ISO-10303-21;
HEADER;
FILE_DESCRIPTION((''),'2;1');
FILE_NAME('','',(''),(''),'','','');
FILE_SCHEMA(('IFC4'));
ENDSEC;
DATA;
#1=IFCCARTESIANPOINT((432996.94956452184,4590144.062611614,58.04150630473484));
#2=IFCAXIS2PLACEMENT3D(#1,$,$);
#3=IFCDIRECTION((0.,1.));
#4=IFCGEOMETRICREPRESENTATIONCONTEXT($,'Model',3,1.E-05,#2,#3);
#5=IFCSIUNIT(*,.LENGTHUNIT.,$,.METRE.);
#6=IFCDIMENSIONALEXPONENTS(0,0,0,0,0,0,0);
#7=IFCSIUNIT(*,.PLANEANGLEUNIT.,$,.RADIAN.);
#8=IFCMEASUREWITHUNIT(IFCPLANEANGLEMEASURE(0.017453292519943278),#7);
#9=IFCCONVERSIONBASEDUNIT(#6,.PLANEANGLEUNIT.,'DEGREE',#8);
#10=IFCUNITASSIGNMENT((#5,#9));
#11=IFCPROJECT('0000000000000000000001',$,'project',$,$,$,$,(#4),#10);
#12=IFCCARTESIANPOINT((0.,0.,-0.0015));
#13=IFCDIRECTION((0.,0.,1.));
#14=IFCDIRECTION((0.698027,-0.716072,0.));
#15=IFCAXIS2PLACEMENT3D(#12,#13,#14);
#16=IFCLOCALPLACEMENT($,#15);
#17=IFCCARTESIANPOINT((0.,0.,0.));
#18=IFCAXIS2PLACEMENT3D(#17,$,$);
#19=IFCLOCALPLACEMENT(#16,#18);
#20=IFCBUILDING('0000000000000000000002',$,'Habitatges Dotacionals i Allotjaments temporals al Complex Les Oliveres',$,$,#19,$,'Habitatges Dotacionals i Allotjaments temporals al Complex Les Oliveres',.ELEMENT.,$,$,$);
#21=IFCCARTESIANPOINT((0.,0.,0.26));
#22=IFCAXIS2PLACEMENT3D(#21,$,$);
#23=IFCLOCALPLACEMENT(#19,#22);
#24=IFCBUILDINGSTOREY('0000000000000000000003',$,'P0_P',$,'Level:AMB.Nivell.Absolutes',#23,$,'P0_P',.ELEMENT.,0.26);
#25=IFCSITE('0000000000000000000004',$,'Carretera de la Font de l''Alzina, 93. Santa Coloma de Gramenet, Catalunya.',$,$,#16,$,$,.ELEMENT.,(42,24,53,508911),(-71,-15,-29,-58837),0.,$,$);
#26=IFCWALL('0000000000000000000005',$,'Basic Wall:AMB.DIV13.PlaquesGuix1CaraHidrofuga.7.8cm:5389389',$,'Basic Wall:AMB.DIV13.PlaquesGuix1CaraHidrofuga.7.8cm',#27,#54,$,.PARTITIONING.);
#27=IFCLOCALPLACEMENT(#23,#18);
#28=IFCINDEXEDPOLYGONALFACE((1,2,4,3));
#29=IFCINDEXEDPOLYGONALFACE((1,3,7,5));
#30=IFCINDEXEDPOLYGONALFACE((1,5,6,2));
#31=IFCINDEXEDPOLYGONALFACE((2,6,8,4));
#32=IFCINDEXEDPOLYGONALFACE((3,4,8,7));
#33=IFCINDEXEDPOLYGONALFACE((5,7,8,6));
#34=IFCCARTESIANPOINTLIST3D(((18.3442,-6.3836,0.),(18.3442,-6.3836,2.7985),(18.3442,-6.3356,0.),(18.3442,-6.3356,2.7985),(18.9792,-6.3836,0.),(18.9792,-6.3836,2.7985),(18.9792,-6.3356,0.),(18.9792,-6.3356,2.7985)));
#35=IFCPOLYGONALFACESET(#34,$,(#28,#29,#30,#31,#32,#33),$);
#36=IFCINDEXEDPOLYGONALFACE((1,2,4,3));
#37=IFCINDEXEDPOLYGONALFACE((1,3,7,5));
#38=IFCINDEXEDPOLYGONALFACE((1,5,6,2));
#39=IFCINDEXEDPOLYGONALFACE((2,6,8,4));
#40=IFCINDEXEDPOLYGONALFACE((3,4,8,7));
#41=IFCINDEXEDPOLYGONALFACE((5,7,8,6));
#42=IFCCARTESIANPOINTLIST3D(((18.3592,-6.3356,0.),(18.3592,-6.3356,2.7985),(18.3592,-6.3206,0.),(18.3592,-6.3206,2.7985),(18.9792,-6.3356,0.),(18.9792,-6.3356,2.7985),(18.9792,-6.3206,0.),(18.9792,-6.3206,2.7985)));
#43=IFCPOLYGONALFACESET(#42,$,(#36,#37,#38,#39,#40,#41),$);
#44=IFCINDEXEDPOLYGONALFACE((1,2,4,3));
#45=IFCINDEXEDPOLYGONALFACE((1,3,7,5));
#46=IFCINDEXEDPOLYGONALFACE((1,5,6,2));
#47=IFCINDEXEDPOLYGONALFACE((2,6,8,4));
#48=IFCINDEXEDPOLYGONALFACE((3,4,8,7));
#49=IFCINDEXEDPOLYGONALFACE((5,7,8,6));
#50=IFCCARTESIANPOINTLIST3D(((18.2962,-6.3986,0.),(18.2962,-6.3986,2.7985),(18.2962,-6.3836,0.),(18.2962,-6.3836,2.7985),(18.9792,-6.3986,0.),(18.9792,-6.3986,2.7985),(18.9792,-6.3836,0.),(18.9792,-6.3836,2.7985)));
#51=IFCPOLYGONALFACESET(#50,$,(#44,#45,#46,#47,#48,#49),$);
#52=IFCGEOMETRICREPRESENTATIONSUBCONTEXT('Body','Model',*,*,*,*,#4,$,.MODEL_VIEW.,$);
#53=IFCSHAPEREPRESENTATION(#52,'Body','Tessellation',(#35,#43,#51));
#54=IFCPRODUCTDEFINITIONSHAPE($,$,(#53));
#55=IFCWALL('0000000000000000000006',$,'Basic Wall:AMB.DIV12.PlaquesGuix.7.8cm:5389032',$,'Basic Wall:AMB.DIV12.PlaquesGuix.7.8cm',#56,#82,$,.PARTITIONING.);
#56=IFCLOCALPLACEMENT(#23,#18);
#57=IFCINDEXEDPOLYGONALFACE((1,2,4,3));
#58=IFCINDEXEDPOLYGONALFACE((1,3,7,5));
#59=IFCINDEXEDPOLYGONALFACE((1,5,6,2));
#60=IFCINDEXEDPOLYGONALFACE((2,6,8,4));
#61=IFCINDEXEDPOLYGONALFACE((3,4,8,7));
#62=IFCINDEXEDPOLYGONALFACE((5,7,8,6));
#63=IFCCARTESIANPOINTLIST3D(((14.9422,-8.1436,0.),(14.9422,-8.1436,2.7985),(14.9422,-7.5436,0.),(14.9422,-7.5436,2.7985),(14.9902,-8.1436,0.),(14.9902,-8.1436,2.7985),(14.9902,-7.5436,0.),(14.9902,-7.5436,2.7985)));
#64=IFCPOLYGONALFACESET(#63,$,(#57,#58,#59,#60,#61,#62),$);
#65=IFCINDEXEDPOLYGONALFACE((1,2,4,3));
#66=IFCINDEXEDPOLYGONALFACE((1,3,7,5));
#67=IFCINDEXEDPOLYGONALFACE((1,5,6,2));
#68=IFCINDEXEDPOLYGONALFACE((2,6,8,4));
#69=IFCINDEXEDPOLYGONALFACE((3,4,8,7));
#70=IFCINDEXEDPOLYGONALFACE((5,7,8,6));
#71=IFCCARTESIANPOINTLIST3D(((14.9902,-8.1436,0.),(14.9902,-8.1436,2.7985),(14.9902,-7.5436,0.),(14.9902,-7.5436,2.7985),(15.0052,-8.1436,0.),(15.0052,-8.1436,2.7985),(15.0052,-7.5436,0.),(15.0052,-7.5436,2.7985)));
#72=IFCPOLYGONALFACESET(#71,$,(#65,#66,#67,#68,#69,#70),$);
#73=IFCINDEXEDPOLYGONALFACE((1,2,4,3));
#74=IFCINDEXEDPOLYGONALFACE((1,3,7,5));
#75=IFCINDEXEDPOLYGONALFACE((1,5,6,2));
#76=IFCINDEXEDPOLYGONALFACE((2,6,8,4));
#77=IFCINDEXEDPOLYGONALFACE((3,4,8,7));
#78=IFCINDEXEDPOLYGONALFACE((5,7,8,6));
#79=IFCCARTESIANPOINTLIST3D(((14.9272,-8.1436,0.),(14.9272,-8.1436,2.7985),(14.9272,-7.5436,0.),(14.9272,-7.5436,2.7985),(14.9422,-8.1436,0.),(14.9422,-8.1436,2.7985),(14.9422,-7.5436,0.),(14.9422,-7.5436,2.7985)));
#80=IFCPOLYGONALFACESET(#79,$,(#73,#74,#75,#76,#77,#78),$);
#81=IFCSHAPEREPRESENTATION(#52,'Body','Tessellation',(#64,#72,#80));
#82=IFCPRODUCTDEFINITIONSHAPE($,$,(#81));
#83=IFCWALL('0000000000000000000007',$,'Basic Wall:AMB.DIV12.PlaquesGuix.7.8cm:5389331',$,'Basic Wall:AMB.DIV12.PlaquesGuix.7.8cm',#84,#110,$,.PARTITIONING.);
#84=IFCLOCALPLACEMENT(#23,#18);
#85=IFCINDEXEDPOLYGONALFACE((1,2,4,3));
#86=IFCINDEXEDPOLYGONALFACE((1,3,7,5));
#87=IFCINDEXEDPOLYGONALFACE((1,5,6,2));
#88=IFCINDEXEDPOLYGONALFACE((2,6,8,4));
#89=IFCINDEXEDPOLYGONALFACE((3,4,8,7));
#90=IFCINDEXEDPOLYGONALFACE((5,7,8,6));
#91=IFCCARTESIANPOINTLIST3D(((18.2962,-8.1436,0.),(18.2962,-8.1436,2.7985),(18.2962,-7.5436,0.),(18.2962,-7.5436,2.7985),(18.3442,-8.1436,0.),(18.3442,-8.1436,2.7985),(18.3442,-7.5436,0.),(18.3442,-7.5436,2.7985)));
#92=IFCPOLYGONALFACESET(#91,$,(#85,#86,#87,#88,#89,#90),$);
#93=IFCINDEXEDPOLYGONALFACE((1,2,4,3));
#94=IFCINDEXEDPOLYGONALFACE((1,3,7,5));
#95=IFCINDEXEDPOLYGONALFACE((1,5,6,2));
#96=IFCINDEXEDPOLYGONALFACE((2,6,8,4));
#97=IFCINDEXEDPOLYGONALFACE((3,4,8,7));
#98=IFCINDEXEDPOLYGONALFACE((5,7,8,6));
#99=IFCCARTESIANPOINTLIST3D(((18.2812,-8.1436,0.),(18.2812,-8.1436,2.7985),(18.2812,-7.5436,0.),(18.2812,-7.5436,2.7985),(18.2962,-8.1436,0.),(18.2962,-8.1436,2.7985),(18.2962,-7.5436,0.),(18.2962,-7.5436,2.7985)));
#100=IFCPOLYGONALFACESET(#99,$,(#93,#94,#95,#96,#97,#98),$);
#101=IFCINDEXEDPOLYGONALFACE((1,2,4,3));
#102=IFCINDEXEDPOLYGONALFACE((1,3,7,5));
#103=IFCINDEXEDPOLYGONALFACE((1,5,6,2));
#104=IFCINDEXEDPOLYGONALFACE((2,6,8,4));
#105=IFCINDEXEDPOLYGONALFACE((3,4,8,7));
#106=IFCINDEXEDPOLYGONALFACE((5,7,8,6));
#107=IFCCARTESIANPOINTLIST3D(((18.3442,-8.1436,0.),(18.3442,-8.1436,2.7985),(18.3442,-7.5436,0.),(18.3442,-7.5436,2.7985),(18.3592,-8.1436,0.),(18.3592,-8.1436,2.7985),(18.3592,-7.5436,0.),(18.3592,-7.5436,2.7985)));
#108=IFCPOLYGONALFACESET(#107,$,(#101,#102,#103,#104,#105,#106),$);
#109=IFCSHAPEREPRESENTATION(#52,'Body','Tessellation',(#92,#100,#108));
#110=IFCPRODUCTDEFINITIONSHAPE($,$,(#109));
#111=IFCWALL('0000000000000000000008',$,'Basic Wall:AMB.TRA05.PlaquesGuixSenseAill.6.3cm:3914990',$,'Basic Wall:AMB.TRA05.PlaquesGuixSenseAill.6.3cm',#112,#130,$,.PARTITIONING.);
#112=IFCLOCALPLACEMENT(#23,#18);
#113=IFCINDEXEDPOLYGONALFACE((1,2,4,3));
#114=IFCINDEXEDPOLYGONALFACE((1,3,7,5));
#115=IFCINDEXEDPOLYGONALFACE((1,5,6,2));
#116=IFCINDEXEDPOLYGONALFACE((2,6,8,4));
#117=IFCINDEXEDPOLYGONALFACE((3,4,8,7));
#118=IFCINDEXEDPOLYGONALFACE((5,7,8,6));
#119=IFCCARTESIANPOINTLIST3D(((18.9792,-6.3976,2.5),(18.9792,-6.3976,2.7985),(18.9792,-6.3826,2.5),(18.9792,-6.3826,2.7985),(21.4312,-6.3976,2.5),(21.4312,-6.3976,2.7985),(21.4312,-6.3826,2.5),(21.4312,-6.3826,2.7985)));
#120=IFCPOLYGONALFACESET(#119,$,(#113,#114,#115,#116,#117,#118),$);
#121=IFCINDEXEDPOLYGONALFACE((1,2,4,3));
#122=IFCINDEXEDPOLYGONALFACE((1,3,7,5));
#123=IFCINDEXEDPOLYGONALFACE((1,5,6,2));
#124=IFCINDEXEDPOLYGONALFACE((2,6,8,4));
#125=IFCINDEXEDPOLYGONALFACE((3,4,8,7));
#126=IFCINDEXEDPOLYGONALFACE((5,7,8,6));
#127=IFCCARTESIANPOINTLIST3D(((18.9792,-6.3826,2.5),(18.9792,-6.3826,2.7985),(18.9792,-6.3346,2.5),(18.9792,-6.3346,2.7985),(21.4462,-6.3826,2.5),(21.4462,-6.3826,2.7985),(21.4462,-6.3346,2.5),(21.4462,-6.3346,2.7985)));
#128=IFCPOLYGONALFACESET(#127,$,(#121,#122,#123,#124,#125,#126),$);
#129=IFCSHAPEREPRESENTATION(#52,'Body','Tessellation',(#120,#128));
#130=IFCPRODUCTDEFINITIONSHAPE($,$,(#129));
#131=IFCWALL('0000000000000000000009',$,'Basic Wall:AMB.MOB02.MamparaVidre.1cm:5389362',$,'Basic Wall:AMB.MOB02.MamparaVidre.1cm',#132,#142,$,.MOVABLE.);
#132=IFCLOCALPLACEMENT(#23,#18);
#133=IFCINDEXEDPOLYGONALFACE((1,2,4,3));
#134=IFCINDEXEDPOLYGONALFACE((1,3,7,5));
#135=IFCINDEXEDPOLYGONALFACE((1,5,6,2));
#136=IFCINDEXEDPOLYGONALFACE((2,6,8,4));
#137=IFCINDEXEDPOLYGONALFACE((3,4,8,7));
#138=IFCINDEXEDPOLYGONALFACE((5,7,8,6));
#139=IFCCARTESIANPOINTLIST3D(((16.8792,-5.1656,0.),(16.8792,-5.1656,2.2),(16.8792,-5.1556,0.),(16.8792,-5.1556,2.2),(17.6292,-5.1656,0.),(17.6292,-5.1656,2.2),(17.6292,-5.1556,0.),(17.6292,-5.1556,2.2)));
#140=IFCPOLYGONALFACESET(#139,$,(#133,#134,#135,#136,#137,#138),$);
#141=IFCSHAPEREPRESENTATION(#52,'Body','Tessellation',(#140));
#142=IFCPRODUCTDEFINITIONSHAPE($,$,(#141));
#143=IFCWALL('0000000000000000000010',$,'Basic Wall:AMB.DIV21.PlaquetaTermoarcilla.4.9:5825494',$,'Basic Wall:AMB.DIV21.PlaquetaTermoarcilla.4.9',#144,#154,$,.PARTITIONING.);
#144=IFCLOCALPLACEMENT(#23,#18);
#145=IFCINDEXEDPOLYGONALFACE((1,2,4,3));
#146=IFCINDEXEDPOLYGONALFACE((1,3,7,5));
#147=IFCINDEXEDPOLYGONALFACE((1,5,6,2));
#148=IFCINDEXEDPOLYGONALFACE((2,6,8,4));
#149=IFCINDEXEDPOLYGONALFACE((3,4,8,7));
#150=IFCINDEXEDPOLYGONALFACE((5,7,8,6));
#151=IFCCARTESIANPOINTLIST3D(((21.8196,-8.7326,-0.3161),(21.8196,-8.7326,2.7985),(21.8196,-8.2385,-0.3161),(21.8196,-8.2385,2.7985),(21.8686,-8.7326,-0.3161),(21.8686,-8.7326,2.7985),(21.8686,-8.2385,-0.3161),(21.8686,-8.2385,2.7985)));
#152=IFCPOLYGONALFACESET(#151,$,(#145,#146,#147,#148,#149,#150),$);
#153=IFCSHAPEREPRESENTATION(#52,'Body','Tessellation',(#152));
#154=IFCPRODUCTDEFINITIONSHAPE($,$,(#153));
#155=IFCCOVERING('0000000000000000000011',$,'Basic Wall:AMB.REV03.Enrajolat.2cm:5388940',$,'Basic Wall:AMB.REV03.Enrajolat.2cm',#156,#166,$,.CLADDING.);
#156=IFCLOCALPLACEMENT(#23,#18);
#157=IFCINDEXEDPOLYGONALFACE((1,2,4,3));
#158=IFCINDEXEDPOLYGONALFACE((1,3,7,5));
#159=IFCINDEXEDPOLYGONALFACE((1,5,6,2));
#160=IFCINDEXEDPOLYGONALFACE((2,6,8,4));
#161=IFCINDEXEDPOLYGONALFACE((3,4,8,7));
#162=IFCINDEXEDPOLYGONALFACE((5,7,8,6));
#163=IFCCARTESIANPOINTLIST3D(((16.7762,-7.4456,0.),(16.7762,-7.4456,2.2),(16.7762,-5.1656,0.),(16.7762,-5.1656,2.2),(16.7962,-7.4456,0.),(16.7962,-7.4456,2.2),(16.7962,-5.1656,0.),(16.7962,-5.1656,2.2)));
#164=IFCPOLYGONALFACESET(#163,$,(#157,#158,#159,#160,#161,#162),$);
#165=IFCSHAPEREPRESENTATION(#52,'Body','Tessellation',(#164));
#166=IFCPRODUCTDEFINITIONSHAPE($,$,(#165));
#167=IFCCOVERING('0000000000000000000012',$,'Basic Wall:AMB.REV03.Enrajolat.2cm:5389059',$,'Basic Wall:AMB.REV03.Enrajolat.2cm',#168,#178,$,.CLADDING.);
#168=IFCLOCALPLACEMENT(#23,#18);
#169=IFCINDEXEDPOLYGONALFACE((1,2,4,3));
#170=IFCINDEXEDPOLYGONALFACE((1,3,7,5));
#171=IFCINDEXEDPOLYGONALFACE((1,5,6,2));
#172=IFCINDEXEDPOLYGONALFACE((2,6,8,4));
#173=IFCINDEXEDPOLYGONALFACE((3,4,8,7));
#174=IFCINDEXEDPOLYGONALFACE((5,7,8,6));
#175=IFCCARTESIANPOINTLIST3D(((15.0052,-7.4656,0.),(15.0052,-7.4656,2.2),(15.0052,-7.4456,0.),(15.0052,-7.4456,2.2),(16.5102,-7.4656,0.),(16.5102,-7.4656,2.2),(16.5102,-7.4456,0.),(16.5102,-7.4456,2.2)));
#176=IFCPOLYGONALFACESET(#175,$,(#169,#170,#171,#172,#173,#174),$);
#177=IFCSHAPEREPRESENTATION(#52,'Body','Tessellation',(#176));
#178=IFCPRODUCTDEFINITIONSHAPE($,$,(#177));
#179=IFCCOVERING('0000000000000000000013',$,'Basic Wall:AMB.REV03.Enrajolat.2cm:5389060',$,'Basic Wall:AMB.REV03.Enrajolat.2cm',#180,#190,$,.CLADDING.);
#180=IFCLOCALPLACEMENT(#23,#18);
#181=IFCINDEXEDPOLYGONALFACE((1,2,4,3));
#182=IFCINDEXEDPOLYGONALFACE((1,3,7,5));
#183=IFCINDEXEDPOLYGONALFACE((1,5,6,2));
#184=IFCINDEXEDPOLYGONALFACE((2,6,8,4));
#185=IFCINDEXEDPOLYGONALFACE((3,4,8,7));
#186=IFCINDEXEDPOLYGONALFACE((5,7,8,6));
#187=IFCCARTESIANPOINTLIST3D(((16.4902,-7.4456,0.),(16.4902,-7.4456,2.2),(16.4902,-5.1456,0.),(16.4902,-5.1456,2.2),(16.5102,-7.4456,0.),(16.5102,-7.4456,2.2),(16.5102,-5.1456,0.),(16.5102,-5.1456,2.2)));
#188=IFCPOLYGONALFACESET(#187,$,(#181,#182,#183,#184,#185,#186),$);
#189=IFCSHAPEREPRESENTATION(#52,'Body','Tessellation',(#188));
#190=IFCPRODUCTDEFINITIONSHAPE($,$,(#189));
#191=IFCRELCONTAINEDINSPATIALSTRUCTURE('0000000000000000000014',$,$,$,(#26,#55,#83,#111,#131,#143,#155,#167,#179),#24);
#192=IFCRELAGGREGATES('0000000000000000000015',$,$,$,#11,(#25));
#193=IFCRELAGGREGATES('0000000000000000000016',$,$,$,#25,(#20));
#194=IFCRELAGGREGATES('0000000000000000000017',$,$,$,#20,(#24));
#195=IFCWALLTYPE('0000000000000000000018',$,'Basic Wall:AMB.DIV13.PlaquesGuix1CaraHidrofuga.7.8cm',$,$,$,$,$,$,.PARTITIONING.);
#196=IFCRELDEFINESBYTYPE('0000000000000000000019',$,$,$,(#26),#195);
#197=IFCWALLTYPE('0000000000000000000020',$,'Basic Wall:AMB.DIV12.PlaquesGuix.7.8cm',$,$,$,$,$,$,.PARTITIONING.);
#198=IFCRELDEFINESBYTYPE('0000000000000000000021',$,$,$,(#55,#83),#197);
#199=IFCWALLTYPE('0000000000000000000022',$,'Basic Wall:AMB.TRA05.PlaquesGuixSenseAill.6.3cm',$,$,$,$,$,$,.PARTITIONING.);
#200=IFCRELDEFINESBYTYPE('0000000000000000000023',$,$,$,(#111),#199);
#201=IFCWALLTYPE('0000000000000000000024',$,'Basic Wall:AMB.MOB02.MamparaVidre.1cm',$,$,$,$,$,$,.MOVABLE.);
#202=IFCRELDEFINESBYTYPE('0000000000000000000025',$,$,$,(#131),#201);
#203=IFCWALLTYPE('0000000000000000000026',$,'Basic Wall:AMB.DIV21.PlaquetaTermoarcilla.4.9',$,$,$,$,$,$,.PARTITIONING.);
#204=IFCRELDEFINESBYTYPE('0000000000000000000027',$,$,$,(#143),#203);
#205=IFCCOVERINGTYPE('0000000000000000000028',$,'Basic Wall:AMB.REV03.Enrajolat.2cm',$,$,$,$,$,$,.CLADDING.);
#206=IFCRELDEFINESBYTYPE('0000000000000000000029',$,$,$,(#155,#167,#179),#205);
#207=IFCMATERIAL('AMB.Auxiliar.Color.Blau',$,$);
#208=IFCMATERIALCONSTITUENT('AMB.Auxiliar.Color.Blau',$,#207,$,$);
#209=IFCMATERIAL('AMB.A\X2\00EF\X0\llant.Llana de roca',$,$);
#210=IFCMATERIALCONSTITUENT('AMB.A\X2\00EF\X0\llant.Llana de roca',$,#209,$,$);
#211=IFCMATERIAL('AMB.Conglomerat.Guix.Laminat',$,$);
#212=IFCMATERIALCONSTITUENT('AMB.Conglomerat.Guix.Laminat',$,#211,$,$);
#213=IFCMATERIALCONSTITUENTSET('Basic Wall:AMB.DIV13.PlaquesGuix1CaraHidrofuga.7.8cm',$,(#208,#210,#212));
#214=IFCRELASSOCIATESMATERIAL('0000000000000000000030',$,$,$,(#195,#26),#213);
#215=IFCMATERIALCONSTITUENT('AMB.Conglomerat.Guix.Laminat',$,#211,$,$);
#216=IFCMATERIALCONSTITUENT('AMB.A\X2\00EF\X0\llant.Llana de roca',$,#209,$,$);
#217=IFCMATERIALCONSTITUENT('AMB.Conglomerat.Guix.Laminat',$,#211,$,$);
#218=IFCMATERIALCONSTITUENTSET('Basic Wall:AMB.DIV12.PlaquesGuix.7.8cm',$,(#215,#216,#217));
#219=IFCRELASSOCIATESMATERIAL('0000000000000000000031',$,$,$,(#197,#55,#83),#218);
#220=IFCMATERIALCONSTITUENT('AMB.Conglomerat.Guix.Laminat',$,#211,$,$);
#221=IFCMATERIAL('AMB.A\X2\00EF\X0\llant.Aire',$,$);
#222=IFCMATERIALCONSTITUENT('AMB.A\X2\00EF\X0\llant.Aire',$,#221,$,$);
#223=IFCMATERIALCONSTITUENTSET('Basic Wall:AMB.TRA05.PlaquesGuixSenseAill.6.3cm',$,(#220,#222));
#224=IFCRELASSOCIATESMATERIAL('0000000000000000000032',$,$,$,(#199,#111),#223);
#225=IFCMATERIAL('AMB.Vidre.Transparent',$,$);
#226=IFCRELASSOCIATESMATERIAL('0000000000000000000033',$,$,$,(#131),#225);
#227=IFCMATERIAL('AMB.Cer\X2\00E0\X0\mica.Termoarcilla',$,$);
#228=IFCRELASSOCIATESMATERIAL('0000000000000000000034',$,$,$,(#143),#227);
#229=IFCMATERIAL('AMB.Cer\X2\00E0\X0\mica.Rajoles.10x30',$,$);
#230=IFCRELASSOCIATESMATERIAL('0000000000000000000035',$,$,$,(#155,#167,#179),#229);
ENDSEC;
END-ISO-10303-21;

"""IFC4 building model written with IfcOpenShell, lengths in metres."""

from ifc_helpers import new_model, entity, si_unit, converted_unit, direction, frame, origin, place, context, subcontext, project, spatial, indexed_curve, outline, extrude, material, constituent, constituent_set, type_object, element, save


model = new_model("IFC4")

# Units and contexts
model_context = context("Model", 3, precision=1e-05, world=frame((432996.94956452184, 4590144.062611614, 58.04150630473484)), true_north=direction((0.0, 1.0)))
body_context = subcontext(model_context, "Body", "Model", "MODEL_VIEW")
ifc_project = project(units=[si_unit("LENGTHUNIT", "METRE"), converted_unit("PLANEANGLEUNIT", "DEGREE", entity("IfcPlaneAngleMeasure", 0.017453292519943278), si_unit("PLANEANGLEUNIT", "RADIAN"), dimensions=[0, 0, 0, 0, 0, 0, 0])], contexts=[model_context])

# Site, building, storey
site_placement = place(None, frame((0.0, 0.0, -0.0015), z_axis=(0.0, 0.0, 1.0), x_axis=(0.698027, -0.716072, 0.0)))
site = spatial("IfcSite", under=ifc_project, at=site_placement, Name="Carretera de la Font de l'Alzina, 93. Santa Coloma de Gramenet, Catalunya.", CompositionType="ELEMENT", RefLatitude=(42, 24, 53, 508911), RefLongitude=(-71, -15, -29, -58837), RefElevation=0.0)
building_placement = place(site_placement, origin())
building = spatial("IfcBuilding", under=site, at=building_placement, Name="Habitatges Dotacionals i Allotjaments temporals al Complex Les Oliveres", LongName="Habitatges Dotacionals i Allotjaments temporals al Complex Les Oliveres", CompositionType="ELEMENT")
storey_placement = place(building_placement, frame((0.0, 0.0, 0.26)))
storey = spatial("IfcBuildingStorey", under=building, at=storey_placement, Name="P0_P", ObjectType="Level:AMB.Nivell.Absolutes", LongName="P0_P", CompositionType="ELEMENT", Elevation=0.26)

# Wall
ifc_material_1 = material(Name="AMB.Ceràmica.Termoarcilla")
ifc_material_2 = material(Name="AMB.Conglomerat.Guix.Laminat")
ifc_material_3 = material(Name="AMB.Aïllant.Llana de roca")
ifc_material_4 = material(Name="AMB.Auxiliar.Color.Blau")
ifc_constituent_1 = constituent(ifc_material_4, Name="AMB.Auxiliar.Color.Blau")
ifc_constituent_2 = constituent(ifc_material_3, Name="AMB.Aïllant.Llana de roca")
ifc_constituent_3 = constituent(ifc_material_2, Name="AMB.Conglomerat.Guix.Laminat")
ifc_constituent_set_1 = constituent_set(constituents=[ifc_constituent_1, ifc_constituent_2, ifc_constituent_3], Name="Basic Wall:AMB.DIV13.PlaquesGuix1CaraHidrofuga.7.8cm")
wall_type_1 = type_object("IfcWallType", Name="Basic Wall:AMB.DIV13.PlaquesGuix1CaraHidrofuga.7.8cm", PredefinedType="PARTITIONING", material=ifc_constituent_set_1)
wall_1_placement = place(storey_placement, frame((18.3592, -6.3596, 0.0)))
element("IfcWall", 1, at=wall_1_placement, inside=storey, type_object=wall_type_1, material=ifc_constituent_set_1, Name="Basic Wall:AMB.DIV13.PlaquesGuix1CaraHidrofuga.7.8cm:5389389", ObjectType="Basic Wall:AMB.DIV13.PlaquesGuix1CaraHidrofuga.7.8cm", PredefinedType="PARTITIONING", context=body_context, shape_type="SweptSolid", body=[
    extrude(outline(indexed_curve([(-0.024, -0.3175), (0.024, -0.3175), (0.024, 0.3175), (-0.024, 0.3175), (-0.024, -0.3175)], self_intersect=False)), frame((0.3025, 0.0, 0.0), z_axis=(0.0, 0.0, 1.0), x_axis=(0.0, 1.0, 0.0)), (0.0, 0.0, 1.0), 2.7985),
    extrude(outline(indexed_curve([(-0.0075, -0.31), (0.0075, -0.31), (0.0075, 0.31), (-0.0075, 0.31), (-0.0075, -0.31)], self_intersect=False)), frame((0.31, 0.0315, 0.0), z_axis=(0.0, 0.0, 1.0), x_axis=(0.0, -1.0, 0.0)), (0.0, 0.0, 1.0), 2.7985),
    extrude(outline(indexed_curve([(-0.0075, -0.3415), (0.0075, -0.3415), (0.0075, 0.3415), (-0.0075, 0.3415), (-0.0075, -0.3415)], self_intersect=False)), frame((0.2785, -0.0315, 0.0), z_axis=(0.0, 0.0, 1.0), x_axis=(0.0, -1.0, 0.0)), (0.0, 0.0, 1.0), 2.7985),
])

# Walls
ifc_constituent_4 = constituent(ifc_material_2, Name="AMB.Conglomerat.Guix.Laminat")
ifc_constituent_5 = constituent(ifc_material_3, Name="AMB.Aïllant.Llana de roca")
ifc_constituent_6 = constituent(ifc_material_2, Name="AMB.Conglomerat.Guix.Laminat")
ifc_constituent_set_2 = constituent_set(constituents=[ifc_constituent_4, ifc_constituent_5, ifc_constituent_6], Name="Basic Wall:AMB.DIV12.PlaquesGuix.7.8cm")
wall_type_2 = type_object("IfcWallType", Name="Basic Wall:AMB.DIV12.PlaquesGuix.7.8cm", PredefinedType="PARTITIONING", material=ifc_constituent_set_2)
wall_2_placement = place(storey_placement, frame((14.9662, -7.5436, 0.0), z_axis=(0.0, 0.0, 1.0), x_axis=(0.0, -1.0, 0.0)))
element("IfcWall", 2, at=wall_2_placement, inside=storey, type_object=wall_type_2, material=ifc_constituent_set_2, Name="Basic Wall:AMB.DIV12.PlaquesGuix.7.8cm:5389032", ObjectType="Basic Wall:AMB.DIV12.PlaquesGuix.7.8cm", PredefinedType="PARTITIONING", context=body_context, shape_type="SweptSolid", body=[
    extrude(outline(indexed_curve([(-0.3, -0.024), (0.3, -0.024), (0.3, 0.024), (-0.3, 0.024), (-0.3, -0.024)], self_intersect=False)), frame((0.3, 0.0, 0.0)), (0.0, 0.0, 1.0), 2.7985),
    extrude(outline(indexed_curve([(-0.0075, -0.3), (0.0075, -0.3), (0.0075, 0.3), (-0.0075, 0.3), (-0.0075, -0.3)], self_intersect=False)), frame((0.3, 0.0315, 0.0), z_axis=(0.0, 0.0, 1.0), x_axis=(0.0, -1.0, 0.0)), (0.0, 0.0, 1.0), 2.7985),
    extrude(outline(indexed_curve([(-0.0075, -0.3), (0.0075, -0.3), (0.0075, 0.3), (-0.0075, 0.3), (-0.0075, -0.3)], self_intersect=False)), frame((0.3, -0.0315, 0.0), z_axis=(0.0, 0.0, 1.0), x_axis=(0.0, 1.0, 0.0)), (0.0, 0.0, 1.0), 2.7985),
])
wall_3_placement = place(storey_placement, frame((18.3202, -7.5436, 0.0), z_axis=(0.0, 0.0, 1.0), x_axis=(0.0, -1.0, 0.0)))
element("IfcWall", 3, at=wall_3_placement, inside=storey, type_object=wall_type_2, material=ifc_constituent_set_2, Name="Basic Wall:AMB.DIV12.PlaquesGuix.7.8cm:5389331", ObjectType="Basic Wall:AMB.DIV12.PlaquesGuix.7.8cm", PredefinedType="PARTITIONING", context=body_context, shape_type="SweptSolid", body=[
    extrude(outline(indexed_curve([(-0.3, -0.024), (0.3, -0.024), (0.3, 0.024), (-0.3, 0.024), (-0.3, -0.024)], self_intersect=False)), frame((0.3, 0.0, 0.0)), (0.0, 0.0, 1.0), 2.7985),
    extrude(outline(indexed_curve([(-0.0075, -0.3), (0.0075, -0.3), (0.0075, 0.3), (-0.0075, 0.3), (-0.0075, -0.3)], self_intersect=False)), frame((0.3, -0.0315, 0.0), z_axis=(0.0, 0.0, 1.0), x_axis=(0.0, 1.0, 0.0)), (0.0, 0.0, 1.0), 2.7985),
    extrude(outline(indexed_curve([(-0.0075, -0.3), (0.0075, -0.3), (0.0075, 0.3), (-0.0075, 0.3), (-0.0075, -0.3)], self_intersect=False)), frame((0.3, 0.0315, 0.0), z_axis=(0.0, 0.0, 1.0), x_axis=(0.0, -1.0, 0.0)), (0.0, 0.0, 1.0), 2.7985),
])
ifc_constituent_7 = constituent(ifc_material_2, Name="AMB.Conglomerat.Guix.Laminat")
ifc_material_5 = material(Name="AMB.Aïllant.Aire")
ifc_constituent_8 = constituent(ifc_material_5, Name="AMB.Aïllant.Aire")
ifc_constituent_set_3 = constituent_set(constituents=[ifc_constituent_7, ifc_constituent_8], Name="Basic Wall:AMB.TRA05.PlaquesGuixSenseAill.6.3cm")
wall_type_3 = type_object("IfcWallType", Name="Basic Wall:AMB.TRA05.PlaquesGuixSenseAill.6.3cm", PredefinedType="PARTITIONING", material=ifc_constituent_set_3)
wall_4_placement = place(storey_placement, frame((18.9792, -6.3661, 2.5)))
element("IfcWall", 4, at=wall_4_placement, inside=storey, type_object=wall_type_3, material=ifc_constituent_set_3, Name="Basic Wall:AMB.TRA05.PlaquesGuixSenseAill.6.3cm:3914990", ObjectType="Basic Wall:AMB.TRA05.PlaquesGuixSenseAill.6.3cm", PredefinedType="PARTITIONING", context=body_context, shape_type="SweptSolid", body=[
    extrude(outline(indexed_curve([(-0.0075, -1.226), (0.0075, -1.226), (0.0075, 1.226), (-0.0075, 1.226), (-0.0075, -1.226)], self_intersect=False)), frame((1.226, -0.024, 0.0), z_axis=(0.0, 0.0, 1.0), x_axis=(0.0, 1.0, 0.0)), (0.0, 0.0, 1.0), 0.2985),
    extrude(outline(indexed_curve([(-0.024, -1.2335), (0.024, -1.2335), (0.024, 1.2335), (-0.024, 1.2335), (-0.024, -1.2335)], self_intersect=False)), frame((1.2335, 0.0075, 0.0), z_axis=(0.0, 0.0, 1.0), x_axis=(0.0, -1.0, 0.0)), (0.0, 0.0, 1.0), 0.2985),
])
ifc_material_6 = material(Name="AMB.Vidre.Transparent")
wall_type_4 = type_object("IfcWallType", Name="Basic Wall:AMB.MOB02.MamparaVidre.1cm", PredefinedType="MOVABLE")
wall_5_placement = place(storey_placement, frame((16.8792, -5.1606, 0.0)))
element("IfcWall", 5, at=wall_5_placement, inside=storey, type_object=wall_type_4, material=ifc_material_6, Name="Basic Wall:AMB.MOB02.MamparaVidre.1cm:5389362", ObjectType="Basic Wall:AMB.MOB02.MamparaVidre.1cm", PredefinedType="MOVABLE", context=body_context, shape_type="SweptSolid", body=[
    extrude(outline(indexed_curve([(0.75, 0.005), (0.0, 0.005), (0.0, -0.005), (0.75, -0.005), (0.75, 0.005)], self_intersect=False)), origin(), (0.0, 0.0, 1.0), 2.2),
])
wall_type_5 = type_object("IfcWallType", Name="Basic Wall:AMB.DIV21.PlaquetaTermoarcilla.4.9", PredefinedType="PARTITIONING")
wall_6_placement = place(storey_placement, frame((21.8441, -8.7326, -0.3161), z_axis=(0.0, 0.0, 1.0), x_axis=(0.0, 1.0, 0.0)))
element("IfcWall", 6, at=wall_6_placement, inside=storey, type_object=wall_type_5, material=ifc_material_1, Name="Basic Wall:AMB.DIV21.PlaquetaTermoarcilla.4.9:5825494", ObjectType="Basic Wall:AMB.DIV21.PlaquetaTermoarcilla.4.9", PredefinedType="PARTITIONING", context=body_context, shape_type="SweptSolid", body=[
    extrude(outline(indexed_curve([(0.4942, 0.0245), (0.0, 0.0245), (0.0, -0.0245), (0.4942, -0.0245), (0.4942, 0.0245)], self_intersect=False)), origin(), (0.0, 0.0, 1.0), 3.1146),
])

# Coverings
ifc_material_7 = material(Name="AMB.Ceràmica.Rajoles.10x30")
covering_type_1 = type_object("IfcCoveringType", Name="Basic Wall:AMB.REV03.Enrajolat.2cm", PredefinedType="CLADDING")
covering_1_placement = place(storey_placement, frame((16.7862, -7.4456, 0.0), z_axis=(0.0, 0.0, 1.0), x_axis=(0.0, 1.0, 0.0)))
element("IfcCovering", 7, at=covering_1_placement, inside=storey, type_object=covering_type_1, material=ifc_material_7, Name="Basic Wall:AMB.REV03.Enrajolat.2cm:5388940", ObjectType="Basic Wall:AMB.REV03.Enrajolat.2cm", PredefinedType="CLADDING", context=body_context, shape_type="SweptSolid", body=[
    extrude(outline(indexed_curve([(2.28, 0.01), (0.0, 0.01), (0.0, -0.01), (2.28, -0.01), (2.28, 0.01)], self_intersect=False)), origin(), (0.0, 0.0, 1.0), 2.2),
])
covering_2_placement = place(storey_placement, frame((15.0052, -7.4556, 0.0)))
element("IfcCovering", 8, at=covering_2_placement, inside=storey, type_object=covering_type_1, material=ifc_material_7, Name="Basic Wall:AMB.REV03.Enrajolat.2cm:5389059", ObjectType="Basic Wall:AMB.REV03.Enrajolat.2cm", PredefinedType="CLADDING", context=body_context, shape_type="SweptSolid", body=[
    extrude(outline(indexed_curve([(1.505, 0.01), (0.0, 0.01), (0.0, -0.01), (1.505, -0.01), (1.505, 0.01)], self_intersect=False)), origin(), (0.0, 0.0, 1.0), 2.2),
])
covering_3_placement = place(storey_placement, frame((16.5002, -7.4456, 0.0), z_axis=(0.0, 0.0, 1.0), x_axis=(0.0, 1.0, 0.0)))
element("IfcCovering", 9, at=covering_3_placement, inside=storey, type_object=covering_type_1, material=ifc_material_7, Name="Basic Wall:AMB.REV03.Enrajolat.2cm:5389060", ObjectType="Basic Wall:AMB.REV03.Enrajolat.2cm", PredefinedType="CLADDING", context=body_context, shape_type="SweptSolid", body=[
    extrude(outline(indexed_curve([(2.3, 0.01), (0.0, 0.01), (0.0, -0.01), (2.3, -0.01), (2.3, 0.01)], self_intersect=False)), origin(), (0.0, 0.0, 1.0), 2.2),
])

save(model, "model.ifc")
